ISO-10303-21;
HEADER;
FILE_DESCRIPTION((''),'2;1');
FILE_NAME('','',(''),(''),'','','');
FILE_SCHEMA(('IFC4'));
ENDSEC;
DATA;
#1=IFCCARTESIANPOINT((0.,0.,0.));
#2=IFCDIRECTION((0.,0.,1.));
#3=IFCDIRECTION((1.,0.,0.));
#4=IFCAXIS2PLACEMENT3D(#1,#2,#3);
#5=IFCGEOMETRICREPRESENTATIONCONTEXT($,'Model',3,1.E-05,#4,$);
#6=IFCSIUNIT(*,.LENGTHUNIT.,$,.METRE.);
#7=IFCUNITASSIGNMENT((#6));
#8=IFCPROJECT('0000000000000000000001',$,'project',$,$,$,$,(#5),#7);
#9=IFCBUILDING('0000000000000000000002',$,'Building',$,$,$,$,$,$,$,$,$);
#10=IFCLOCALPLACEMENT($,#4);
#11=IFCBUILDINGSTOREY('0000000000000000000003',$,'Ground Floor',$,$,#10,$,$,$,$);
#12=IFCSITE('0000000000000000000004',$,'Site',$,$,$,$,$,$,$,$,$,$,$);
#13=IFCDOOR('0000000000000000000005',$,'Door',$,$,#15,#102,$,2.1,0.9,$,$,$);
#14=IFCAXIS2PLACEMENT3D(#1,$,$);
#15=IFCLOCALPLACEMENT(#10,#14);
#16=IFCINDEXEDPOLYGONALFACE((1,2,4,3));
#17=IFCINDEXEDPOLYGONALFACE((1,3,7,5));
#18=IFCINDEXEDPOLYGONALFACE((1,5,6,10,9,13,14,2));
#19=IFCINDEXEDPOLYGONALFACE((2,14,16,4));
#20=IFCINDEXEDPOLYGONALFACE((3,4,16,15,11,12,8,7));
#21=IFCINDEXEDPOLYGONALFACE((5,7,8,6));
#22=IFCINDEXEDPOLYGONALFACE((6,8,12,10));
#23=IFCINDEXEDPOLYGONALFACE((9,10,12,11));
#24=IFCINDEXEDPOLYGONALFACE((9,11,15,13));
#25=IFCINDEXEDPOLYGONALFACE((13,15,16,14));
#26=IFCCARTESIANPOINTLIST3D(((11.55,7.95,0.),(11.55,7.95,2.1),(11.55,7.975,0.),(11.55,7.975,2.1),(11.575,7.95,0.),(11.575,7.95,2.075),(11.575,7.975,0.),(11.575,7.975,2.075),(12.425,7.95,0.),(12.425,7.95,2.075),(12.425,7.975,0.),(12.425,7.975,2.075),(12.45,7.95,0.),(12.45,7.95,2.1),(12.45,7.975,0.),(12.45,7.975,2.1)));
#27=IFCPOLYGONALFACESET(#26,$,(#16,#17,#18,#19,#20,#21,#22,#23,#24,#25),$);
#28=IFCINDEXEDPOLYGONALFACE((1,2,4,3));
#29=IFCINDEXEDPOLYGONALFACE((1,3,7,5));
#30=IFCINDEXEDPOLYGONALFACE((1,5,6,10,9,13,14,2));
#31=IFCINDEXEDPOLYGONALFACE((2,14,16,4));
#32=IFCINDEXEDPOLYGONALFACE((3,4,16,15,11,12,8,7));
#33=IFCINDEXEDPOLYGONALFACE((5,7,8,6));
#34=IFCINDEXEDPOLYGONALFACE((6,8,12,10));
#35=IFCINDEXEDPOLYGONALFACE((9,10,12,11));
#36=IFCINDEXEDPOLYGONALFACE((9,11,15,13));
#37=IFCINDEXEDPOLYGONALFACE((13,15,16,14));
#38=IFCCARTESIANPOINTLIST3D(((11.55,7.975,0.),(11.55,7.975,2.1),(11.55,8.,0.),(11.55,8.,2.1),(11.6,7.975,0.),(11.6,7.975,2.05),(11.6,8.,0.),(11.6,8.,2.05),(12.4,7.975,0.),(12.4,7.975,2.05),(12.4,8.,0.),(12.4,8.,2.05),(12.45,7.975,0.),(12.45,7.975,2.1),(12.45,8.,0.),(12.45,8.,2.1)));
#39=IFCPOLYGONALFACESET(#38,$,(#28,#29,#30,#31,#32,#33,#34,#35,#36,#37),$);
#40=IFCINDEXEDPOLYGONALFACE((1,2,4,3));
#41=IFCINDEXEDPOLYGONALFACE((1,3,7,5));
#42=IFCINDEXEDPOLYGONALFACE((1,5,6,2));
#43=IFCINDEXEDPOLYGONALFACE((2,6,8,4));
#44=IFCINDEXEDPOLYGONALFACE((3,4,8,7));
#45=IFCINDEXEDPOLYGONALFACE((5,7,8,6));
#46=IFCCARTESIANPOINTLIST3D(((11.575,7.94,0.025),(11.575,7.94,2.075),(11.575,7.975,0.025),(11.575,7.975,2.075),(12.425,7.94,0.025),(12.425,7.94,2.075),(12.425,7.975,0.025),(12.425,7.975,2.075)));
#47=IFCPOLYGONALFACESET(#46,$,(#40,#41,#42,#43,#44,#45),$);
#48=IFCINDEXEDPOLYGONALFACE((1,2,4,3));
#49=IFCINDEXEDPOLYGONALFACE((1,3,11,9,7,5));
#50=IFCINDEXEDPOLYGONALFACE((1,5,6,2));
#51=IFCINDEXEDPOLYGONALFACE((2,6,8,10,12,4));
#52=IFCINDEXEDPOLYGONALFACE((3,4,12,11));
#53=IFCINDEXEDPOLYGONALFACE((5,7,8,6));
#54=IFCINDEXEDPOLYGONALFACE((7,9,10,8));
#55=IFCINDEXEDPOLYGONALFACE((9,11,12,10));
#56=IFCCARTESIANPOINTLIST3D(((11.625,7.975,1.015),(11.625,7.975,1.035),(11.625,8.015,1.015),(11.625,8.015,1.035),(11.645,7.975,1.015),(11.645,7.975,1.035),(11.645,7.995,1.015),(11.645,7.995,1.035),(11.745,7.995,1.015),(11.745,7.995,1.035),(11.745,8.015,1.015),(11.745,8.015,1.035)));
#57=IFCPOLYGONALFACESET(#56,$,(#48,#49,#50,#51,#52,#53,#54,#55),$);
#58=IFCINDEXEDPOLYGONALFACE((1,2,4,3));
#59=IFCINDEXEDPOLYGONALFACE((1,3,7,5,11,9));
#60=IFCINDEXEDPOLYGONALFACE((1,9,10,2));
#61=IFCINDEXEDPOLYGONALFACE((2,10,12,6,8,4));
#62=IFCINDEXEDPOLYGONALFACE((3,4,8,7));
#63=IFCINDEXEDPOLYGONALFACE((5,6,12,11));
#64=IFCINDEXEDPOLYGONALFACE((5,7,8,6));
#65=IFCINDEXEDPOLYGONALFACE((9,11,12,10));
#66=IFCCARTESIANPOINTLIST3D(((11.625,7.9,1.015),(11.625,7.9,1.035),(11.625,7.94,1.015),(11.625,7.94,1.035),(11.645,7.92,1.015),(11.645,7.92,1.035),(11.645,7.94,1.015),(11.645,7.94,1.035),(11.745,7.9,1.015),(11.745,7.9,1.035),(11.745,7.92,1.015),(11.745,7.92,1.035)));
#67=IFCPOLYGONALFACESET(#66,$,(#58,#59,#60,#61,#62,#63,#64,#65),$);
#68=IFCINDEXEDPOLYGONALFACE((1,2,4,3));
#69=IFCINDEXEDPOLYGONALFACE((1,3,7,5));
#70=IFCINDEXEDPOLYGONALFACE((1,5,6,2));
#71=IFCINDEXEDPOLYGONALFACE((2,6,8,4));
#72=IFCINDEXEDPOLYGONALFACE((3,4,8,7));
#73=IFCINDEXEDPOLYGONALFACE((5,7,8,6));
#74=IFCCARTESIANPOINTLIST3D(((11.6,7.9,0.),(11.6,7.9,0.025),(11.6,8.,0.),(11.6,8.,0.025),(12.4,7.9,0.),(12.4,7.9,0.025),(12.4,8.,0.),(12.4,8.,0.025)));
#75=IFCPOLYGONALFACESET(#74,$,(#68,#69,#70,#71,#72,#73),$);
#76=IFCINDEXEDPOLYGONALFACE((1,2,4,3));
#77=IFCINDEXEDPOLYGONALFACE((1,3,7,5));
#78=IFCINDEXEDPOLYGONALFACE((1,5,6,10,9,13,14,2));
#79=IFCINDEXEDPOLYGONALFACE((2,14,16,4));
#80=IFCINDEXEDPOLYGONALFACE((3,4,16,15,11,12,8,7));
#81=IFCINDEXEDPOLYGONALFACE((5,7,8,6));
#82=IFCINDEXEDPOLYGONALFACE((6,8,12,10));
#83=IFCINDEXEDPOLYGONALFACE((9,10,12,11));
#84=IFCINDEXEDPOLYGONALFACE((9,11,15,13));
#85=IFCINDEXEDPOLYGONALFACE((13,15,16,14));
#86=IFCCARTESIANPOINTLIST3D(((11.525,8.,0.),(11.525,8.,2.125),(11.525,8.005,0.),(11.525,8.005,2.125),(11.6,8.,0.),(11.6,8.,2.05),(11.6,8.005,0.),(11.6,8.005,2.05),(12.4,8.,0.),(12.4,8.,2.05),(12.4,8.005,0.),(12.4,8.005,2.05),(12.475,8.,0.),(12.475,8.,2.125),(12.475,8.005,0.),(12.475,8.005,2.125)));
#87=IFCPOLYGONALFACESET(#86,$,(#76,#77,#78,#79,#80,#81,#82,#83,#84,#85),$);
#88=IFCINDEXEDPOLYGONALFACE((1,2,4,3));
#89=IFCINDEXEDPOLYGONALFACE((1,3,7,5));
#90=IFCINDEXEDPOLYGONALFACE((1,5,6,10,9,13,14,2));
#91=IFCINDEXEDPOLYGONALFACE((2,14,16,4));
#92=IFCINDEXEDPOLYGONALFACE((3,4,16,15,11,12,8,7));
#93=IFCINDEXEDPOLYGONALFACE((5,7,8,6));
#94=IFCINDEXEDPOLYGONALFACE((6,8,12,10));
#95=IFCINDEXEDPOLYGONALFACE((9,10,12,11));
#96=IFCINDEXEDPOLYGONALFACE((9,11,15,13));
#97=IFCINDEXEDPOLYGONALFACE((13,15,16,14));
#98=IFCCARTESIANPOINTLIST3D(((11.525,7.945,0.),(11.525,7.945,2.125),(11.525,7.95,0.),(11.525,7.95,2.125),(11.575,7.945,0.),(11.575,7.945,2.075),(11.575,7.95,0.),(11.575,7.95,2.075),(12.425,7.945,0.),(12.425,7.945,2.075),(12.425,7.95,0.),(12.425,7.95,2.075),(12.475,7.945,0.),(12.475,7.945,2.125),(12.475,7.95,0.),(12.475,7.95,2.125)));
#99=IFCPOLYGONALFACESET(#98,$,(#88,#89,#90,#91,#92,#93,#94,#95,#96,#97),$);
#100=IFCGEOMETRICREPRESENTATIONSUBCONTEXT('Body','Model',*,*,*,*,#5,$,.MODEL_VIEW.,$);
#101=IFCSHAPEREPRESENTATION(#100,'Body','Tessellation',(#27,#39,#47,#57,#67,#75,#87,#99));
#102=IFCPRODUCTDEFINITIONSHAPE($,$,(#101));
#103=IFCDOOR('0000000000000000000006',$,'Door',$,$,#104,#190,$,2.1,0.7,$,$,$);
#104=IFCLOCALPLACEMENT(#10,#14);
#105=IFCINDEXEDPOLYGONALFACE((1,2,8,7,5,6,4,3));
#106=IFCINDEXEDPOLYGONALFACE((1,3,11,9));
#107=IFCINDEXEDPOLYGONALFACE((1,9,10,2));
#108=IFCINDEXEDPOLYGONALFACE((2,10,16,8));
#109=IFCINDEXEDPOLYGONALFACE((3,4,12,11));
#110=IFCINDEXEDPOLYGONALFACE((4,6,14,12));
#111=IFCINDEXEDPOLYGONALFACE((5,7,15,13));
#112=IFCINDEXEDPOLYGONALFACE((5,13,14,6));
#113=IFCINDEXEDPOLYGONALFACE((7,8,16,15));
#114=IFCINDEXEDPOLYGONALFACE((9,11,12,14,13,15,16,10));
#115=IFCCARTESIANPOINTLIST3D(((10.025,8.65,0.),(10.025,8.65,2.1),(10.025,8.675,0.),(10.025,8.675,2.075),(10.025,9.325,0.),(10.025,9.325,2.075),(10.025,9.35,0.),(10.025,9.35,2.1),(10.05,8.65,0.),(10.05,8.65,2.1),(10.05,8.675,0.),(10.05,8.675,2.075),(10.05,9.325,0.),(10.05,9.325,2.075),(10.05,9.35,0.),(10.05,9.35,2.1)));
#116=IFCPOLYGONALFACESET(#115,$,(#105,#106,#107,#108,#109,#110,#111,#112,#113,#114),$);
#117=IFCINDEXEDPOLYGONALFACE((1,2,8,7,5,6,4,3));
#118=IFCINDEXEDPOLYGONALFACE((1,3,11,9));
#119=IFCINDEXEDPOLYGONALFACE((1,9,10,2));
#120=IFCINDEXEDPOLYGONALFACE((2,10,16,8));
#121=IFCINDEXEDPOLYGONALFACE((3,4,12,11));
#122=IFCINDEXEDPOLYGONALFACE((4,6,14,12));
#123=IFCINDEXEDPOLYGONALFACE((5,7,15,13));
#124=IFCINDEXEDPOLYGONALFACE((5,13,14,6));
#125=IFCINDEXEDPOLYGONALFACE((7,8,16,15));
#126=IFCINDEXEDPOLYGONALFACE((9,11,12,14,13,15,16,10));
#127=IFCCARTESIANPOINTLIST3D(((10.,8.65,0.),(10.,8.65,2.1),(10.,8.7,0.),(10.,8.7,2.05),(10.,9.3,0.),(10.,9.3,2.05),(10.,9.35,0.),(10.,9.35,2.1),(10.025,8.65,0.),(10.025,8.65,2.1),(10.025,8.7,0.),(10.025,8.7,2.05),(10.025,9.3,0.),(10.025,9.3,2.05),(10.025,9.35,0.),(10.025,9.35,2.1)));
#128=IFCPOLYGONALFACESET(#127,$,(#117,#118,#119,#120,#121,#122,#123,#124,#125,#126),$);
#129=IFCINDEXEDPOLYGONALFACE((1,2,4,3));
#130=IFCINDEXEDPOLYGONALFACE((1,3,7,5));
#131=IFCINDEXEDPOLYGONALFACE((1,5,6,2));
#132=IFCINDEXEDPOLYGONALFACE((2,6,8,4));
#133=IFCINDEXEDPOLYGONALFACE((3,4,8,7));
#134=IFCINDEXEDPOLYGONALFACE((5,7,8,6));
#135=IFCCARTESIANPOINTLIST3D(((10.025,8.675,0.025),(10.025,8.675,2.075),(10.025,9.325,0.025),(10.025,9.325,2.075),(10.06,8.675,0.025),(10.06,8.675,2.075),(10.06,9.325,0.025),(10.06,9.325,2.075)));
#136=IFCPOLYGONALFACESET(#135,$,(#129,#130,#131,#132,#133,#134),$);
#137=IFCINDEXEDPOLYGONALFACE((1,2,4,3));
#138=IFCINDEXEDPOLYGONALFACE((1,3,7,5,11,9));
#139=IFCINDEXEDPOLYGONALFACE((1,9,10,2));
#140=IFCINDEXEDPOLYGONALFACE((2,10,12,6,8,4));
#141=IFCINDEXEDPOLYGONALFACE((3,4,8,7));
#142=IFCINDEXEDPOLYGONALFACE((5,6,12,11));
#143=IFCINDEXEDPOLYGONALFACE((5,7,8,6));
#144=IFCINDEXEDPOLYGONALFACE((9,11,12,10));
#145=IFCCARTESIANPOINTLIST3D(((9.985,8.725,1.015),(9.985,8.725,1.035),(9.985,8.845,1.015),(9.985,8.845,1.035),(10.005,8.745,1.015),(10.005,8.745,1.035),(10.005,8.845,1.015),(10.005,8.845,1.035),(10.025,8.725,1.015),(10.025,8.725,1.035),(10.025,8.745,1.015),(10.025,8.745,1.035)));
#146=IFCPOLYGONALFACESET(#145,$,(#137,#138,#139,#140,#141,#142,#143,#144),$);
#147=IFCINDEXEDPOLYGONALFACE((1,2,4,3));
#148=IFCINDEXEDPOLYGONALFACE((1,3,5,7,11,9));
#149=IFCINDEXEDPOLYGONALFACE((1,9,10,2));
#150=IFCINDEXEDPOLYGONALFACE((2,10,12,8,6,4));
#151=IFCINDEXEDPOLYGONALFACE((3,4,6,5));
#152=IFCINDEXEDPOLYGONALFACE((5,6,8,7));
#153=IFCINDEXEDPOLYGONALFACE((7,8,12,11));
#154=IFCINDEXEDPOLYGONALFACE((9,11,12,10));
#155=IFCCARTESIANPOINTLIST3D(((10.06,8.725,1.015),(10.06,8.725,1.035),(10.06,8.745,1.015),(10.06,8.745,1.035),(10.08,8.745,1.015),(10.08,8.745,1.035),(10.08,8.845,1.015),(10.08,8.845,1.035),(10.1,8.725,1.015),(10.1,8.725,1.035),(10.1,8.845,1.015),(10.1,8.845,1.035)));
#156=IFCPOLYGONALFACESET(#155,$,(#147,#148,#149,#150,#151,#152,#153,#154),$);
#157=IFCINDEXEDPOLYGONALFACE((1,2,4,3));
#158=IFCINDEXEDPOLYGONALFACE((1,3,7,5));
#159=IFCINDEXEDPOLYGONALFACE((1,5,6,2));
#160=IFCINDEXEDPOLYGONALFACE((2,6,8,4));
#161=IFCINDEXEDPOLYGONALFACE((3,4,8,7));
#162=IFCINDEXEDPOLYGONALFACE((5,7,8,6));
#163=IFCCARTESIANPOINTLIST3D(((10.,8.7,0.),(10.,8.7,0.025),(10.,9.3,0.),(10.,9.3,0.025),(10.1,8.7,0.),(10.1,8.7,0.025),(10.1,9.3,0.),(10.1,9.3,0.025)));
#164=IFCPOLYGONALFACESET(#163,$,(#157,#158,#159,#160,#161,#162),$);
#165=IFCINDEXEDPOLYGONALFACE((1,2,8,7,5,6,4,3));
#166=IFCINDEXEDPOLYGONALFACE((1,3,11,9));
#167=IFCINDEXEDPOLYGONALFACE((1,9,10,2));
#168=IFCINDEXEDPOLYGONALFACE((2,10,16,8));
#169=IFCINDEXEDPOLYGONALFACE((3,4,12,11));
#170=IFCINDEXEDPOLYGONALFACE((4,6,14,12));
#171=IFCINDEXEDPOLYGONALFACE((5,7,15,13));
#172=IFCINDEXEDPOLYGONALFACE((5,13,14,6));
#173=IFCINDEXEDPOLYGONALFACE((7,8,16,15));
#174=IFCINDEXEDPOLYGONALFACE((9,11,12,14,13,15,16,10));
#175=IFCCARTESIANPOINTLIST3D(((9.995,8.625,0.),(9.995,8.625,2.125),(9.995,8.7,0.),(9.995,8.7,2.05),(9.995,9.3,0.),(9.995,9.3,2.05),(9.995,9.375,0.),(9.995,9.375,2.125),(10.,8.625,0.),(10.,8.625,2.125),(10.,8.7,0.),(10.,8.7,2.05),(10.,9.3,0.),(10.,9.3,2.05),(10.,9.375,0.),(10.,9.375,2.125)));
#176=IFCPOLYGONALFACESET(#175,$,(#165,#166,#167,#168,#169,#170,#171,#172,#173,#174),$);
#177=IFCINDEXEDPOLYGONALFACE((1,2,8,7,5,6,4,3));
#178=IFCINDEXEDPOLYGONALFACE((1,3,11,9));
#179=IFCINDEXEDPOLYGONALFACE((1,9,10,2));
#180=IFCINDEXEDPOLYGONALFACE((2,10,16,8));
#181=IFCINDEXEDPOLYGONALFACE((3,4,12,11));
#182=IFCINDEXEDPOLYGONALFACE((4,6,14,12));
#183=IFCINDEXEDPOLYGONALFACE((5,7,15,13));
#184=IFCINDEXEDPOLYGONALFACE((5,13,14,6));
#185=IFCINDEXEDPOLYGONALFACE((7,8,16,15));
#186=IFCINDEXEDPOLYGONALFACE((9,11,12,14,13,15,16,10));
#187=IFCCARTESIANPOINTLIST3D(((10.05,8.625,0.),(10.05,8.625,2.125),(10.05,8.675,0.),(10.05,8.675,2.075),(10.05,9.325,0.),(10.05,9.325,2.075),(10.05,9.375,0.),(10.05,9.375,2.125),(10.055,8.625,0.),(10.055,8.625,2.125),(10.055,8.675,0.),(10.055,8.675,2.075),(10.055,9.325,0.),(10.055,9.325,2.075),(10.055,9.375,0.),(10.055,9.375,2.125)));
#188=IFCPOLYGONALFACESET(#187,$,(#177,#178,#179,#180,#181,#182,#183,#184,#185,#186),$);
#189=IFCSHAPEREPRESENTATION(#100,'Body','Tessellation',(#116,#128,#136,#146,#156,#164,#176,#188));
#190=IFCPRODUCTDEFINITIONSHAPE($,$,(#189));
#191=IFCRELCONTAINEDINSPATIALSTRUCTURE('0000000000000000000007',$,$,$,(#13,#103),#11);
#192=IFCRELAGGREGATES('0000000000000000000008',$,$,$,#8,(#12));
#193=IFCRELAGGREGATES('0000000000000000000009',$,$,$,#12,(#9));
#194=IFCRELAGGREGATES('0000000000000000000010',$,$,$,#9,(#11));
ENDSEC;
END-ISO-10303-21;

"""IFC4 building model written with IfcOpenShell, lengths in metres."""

from ifc_helpers import new_model, si_unit, frame, origin_with_axes, place, context, subcontext, project, spatial, line, indexed_curve, outline, extrude, element, save


model = new_model("IFC4")

# Units and contexts
model_context = context("Model", 3, precision=1e-05, world=origin_with_axes())
body_context = subcontext(model_context, "Body", "Model", "MODEL_VIEW")
ifc_project = project(units=[si_unit("LENGTHUNIT", "METRE")], contexts=[model_context])

# Site, building, storey
site = spatial("IfcSite", under=ifc_project, Name="Site")
building = spatial("IfcBuilding", under=site, Name="Building")
storey_placement = place(None, origin_with_axes())
storey = spatial("IfcBuildingStorey", under=building, at=storey_placement, Name="Ground Floor")

# Doors
door_1_placement = place(storey_placement, frame((12.45, 8.0, 0.0), z_axis=(0.0, 0.0, 1.0), x_axis=(-1.0, 0.0, 0.0)))
element("IfcDoor", 1, at=door_1_placement, inside=storey, Name="Door", OverallHeight=2.1, OverallWidth=0.9, context=body_context, shape_type="SweptSolid", body=[
    extrude(outline(indexed_curve([(0.0, 0.0), (0.0, 2.1), (0.9, 2.1), (0.9, 0.0), (0.875, 0.0), (0.875, 2.075), (0.025, 2.075), (0.025, 0.0)], segments=[line(1, 2, 3, 4, 5, 6, 7, 8, 1)])), frame((0.0, 0.025, 0.0), z_axis=(0.0, -1.0, 0.0), x_axis=(1.0, 0.0, 0.0)), (0.0, 0.0, -1.0), 0.025),
    extrude(outline(indexed_curve([(0.0, 0.0), (0.0, 2.1), (0.9, 2.1), (0.9, 0.0), (0.85, 0.0), (0.85, 2.05), (0.05, 2.05), (0.05, 0.0)], segments=[line(1, 2, 3, 4, 5, 6, 7, 8, 1)])), frame((0.0, 0.0, 0.0), z_axis=(0.0, -1.0, 0.0), x_axis=(1.0, 0.0, 0.0)), (0.0, 0.0, -1.0), 0.025),
    extrude(outline(indexed_curve([(0.0, 0.0), (0.85, 0.0), (0.85, 0.035), (0.0, 0.035)], segments=[line(1, 2, 3, 4, 1)])), frame((0.025, 0.025, 0.025), z_axis=(0.0, 0.0, 1.0), x_axis=(1.0, 0.0, 0.0)), (0.0, 0.0, 1.0), 2.05),
    extrude(outline(indexed_curve([(0.0, 0.0), (0.0, -0.04), (-0.12, -0.04), (-0.12, -0.02), (-0.02, -0.02), (-0.02, 0.0)], segments=[line(1, 2, 3, 4, 5, 6, 1)])), frame((0.825, 0.025, 1.015), z_axis=(0.0, 0.0, 1.0), x_axis=(1.0, 0.0, 0.0)), (0.0, 0.0, 1.0), 0.02),
    extrude(outline(indexed_curve([(0.0, 0.0), (0.0, 0.04), (-0.12, 0.04), (-0.12, 0.02), (-0.02, 0.02), (-0.02, 0.0)], segments=[line(1, 2, 3, 4, 5, 6, 1)])), frame((0.825, 0.06, 1.015), z_axis=(0.0, 0.0, 1.0), x_axis=(1.0, 0.0, 0.0)), (0.0, 0.0, 1.0), 0.02),
    extrude(outline(indexed_curve([(0.0, 0.0), (0.8, 0.0), (0.8, 0.1), (0.0, 0.1)], segments=[line(1, 2, 3, 4, 1)])), frame((0.05, 0.0, 0.0), z_axis=(0.0, 0.0, 1.0), x_axis=(1.0, 0.0, 0.0)), (0.0, 0.0, 1.0), 0.025),
    extrude(outline(indexed_curve([(0.0, 0.0), (0.0, 2.125), (0.95, 2.125), (0.95, 0.0), (0.875, 0.0), (0.875, 2.05), (0.075, 2.05), (0.075, 0.0)], segments=[line(1, 2, 3, 4, 5, 6, 7, 8, 1)])), frame((-0.025, -0.005, 0.0), z_axis=(0.0, -1.0, 0.0), x_axis=(1.0, 0.0, 0.0)), (0.0, 0.0, -1.0), 0.005),
    extrude(outline(indexed_curve([(0.0, 0.0), (0.0, 2.125), (0.95, 2.125), (0.95, 0.0), (0.9, 0.0), (0.9, 2.075), (0.05, 2.075), (0.05, 0.0)], segments=[line(1, 2, 3, 4, 5, 6, 7, 8, 1)])), frame((-0.025, 0.05, 0.0), z_axis=(0.0, -1.0, 0.0), x_axis=(1.0, 0.0, 0.0)), (0.0, 0.0, -1.0), 0.005),
])
door_2_placement = place(storey_placement, frame((10.0, 9.35, 0.0), z_axis=(0.0, 0.0, 1.0), x_axis=(0.0, -1.0, 0.0)))
element("IfcDoor", 2, at=door_2_placement, inside=storey, Name="Door", OverallHeight=2.1, OverallWidth=0.7, context=body_context, shape_type="SweptSolid", body=[
    extrude(outline(indexed_curve([(0.0, 0.0), (0.0, 2.1), (0.7, 2.1), (0.7, 0.0), (0.675, 0.0), (0.675, 2.075), (0.025, 2.075), (0.025, 0.0)], segments=[line(1, 2, 3, 4, 5, 6, 7, 8, 1)])), frame((0.0, 0.025, 0.0), z_axis=(0.0, -1.0, 0.0), x_axis=(1.0, 0.0, 0.0)), (0.0, 0.0, -1.0), 0.025),
    extrude(outline(indexed_curve([(0.0, 0.0), (0.0, 2.1), (0.7, 2.1), (0.7, 0.0), (0.65, 0.0), (0.65, 2.05), (0.05, 2.05), (0.05, 0.0)], segments=[line(1, 2, 3, 4, 5, 6, 7, 8, 1)])), frame((0.0, 0.0, 0.0), z_axis=(0.0, -1.0, 0.0), x_axis=(1.0, 0.0, 0.0)), (0.0, 0.0, -1.0), 0.025),
    extrude(outline(indexed_curve([(0.0, 0.0), (0.65, 0.0), (0.65, 0.035), (0.0, 0.035)], segments=[line(1, 2, 3, 4, 1)])), frame((0.025, 0.025, 0.025), z_axis=(0.0, 0.0, 1.0), x_axis=(1.0, 0.0, 0.0)), (0.0, 0.0, 1.0), 2.05),
    extrude(outline(indexed_curve([(0.0, 0.0), (0.0, -0.04), (-0.12, -0.04), (-0.12, -0.02), (-0.02, -0.02), (-0.02, 0.0)], segments=[line(1, 2, 3, 4, 5, 6, 1)])), frame((0.625, 0.025, 1.015), z_axis=(0.0, 0.0, 1.0), x_axis=(1.0, 0.0, 0.0)), (0.0, 0.0, 1.0), 0.02),
    extrude(outline(indexed_curve([(0.0, 0.0), (0.0, 0.04), (-0.12, 0.04), (-0.12, 0.02), (-0.02, 0.02), (-0.02, 0.0)], segments=[line(1, 2, 3, 4, 5, 6, 1)])), frame((0.625, 0.06, 1.015), z_axis=(0.0, 0.0, 1.0), x_axis=(1.0, 0.0, 0.0)), (0.0, 0.0, 1.0), 0.02),
    extrude(outline(indexed_curve([(0.0, 0.0), (0.6, 0.0), (0.6, 0.1), (0.0, 0.1)], segments=[line(1, 2, 3, 4, 1)])), frame((0.05, 0.0, 0.0), z_axis=(0.0, 0.0, 1.0), x_axis=(1.0, 0.0, 0.0)), (0.0, 0.0, 1.0), 0.025),
    extrude(outline(indexed_curve([(0.0, 0.0), (0.0, 2.125), (0.75, 2.125), (0.75, 0.0), (0.675, 0.0), (0.675, 2.05), (0.075, 2.05), (0.075, 0.0)], segments=[line(1, 2, 3, 4, 5, 6, 7, 8, 1)])), frame((-0.025, -0.005, 0.0), z_axis=(0.0, -1.0, 0.0), x_axis=(1.0, 0.0, 0.0)), (0.0, 0.0, -1.0), 0.005),
    extrude(outline(indexed_curve([(0.0, 0.0), (0.0, 2.125), (0.75, 2.125), (0.75, 0.0), (0.7, 0.0), (0.7, 2.075), (0.05, 2.075), (0.05, 0.0)], segments=[line(1, 2, 3, 4, 5, 6, 7, 8, 1)])), frame((-0.025, 0.05, 0.0), z_axis=(0.0, -1.0, 0.0), x_axis=(1.0, 0.0, 0.0)), (0.0, 0.0, -1.0), 0.005),
])

save(model, "model.ifc")
